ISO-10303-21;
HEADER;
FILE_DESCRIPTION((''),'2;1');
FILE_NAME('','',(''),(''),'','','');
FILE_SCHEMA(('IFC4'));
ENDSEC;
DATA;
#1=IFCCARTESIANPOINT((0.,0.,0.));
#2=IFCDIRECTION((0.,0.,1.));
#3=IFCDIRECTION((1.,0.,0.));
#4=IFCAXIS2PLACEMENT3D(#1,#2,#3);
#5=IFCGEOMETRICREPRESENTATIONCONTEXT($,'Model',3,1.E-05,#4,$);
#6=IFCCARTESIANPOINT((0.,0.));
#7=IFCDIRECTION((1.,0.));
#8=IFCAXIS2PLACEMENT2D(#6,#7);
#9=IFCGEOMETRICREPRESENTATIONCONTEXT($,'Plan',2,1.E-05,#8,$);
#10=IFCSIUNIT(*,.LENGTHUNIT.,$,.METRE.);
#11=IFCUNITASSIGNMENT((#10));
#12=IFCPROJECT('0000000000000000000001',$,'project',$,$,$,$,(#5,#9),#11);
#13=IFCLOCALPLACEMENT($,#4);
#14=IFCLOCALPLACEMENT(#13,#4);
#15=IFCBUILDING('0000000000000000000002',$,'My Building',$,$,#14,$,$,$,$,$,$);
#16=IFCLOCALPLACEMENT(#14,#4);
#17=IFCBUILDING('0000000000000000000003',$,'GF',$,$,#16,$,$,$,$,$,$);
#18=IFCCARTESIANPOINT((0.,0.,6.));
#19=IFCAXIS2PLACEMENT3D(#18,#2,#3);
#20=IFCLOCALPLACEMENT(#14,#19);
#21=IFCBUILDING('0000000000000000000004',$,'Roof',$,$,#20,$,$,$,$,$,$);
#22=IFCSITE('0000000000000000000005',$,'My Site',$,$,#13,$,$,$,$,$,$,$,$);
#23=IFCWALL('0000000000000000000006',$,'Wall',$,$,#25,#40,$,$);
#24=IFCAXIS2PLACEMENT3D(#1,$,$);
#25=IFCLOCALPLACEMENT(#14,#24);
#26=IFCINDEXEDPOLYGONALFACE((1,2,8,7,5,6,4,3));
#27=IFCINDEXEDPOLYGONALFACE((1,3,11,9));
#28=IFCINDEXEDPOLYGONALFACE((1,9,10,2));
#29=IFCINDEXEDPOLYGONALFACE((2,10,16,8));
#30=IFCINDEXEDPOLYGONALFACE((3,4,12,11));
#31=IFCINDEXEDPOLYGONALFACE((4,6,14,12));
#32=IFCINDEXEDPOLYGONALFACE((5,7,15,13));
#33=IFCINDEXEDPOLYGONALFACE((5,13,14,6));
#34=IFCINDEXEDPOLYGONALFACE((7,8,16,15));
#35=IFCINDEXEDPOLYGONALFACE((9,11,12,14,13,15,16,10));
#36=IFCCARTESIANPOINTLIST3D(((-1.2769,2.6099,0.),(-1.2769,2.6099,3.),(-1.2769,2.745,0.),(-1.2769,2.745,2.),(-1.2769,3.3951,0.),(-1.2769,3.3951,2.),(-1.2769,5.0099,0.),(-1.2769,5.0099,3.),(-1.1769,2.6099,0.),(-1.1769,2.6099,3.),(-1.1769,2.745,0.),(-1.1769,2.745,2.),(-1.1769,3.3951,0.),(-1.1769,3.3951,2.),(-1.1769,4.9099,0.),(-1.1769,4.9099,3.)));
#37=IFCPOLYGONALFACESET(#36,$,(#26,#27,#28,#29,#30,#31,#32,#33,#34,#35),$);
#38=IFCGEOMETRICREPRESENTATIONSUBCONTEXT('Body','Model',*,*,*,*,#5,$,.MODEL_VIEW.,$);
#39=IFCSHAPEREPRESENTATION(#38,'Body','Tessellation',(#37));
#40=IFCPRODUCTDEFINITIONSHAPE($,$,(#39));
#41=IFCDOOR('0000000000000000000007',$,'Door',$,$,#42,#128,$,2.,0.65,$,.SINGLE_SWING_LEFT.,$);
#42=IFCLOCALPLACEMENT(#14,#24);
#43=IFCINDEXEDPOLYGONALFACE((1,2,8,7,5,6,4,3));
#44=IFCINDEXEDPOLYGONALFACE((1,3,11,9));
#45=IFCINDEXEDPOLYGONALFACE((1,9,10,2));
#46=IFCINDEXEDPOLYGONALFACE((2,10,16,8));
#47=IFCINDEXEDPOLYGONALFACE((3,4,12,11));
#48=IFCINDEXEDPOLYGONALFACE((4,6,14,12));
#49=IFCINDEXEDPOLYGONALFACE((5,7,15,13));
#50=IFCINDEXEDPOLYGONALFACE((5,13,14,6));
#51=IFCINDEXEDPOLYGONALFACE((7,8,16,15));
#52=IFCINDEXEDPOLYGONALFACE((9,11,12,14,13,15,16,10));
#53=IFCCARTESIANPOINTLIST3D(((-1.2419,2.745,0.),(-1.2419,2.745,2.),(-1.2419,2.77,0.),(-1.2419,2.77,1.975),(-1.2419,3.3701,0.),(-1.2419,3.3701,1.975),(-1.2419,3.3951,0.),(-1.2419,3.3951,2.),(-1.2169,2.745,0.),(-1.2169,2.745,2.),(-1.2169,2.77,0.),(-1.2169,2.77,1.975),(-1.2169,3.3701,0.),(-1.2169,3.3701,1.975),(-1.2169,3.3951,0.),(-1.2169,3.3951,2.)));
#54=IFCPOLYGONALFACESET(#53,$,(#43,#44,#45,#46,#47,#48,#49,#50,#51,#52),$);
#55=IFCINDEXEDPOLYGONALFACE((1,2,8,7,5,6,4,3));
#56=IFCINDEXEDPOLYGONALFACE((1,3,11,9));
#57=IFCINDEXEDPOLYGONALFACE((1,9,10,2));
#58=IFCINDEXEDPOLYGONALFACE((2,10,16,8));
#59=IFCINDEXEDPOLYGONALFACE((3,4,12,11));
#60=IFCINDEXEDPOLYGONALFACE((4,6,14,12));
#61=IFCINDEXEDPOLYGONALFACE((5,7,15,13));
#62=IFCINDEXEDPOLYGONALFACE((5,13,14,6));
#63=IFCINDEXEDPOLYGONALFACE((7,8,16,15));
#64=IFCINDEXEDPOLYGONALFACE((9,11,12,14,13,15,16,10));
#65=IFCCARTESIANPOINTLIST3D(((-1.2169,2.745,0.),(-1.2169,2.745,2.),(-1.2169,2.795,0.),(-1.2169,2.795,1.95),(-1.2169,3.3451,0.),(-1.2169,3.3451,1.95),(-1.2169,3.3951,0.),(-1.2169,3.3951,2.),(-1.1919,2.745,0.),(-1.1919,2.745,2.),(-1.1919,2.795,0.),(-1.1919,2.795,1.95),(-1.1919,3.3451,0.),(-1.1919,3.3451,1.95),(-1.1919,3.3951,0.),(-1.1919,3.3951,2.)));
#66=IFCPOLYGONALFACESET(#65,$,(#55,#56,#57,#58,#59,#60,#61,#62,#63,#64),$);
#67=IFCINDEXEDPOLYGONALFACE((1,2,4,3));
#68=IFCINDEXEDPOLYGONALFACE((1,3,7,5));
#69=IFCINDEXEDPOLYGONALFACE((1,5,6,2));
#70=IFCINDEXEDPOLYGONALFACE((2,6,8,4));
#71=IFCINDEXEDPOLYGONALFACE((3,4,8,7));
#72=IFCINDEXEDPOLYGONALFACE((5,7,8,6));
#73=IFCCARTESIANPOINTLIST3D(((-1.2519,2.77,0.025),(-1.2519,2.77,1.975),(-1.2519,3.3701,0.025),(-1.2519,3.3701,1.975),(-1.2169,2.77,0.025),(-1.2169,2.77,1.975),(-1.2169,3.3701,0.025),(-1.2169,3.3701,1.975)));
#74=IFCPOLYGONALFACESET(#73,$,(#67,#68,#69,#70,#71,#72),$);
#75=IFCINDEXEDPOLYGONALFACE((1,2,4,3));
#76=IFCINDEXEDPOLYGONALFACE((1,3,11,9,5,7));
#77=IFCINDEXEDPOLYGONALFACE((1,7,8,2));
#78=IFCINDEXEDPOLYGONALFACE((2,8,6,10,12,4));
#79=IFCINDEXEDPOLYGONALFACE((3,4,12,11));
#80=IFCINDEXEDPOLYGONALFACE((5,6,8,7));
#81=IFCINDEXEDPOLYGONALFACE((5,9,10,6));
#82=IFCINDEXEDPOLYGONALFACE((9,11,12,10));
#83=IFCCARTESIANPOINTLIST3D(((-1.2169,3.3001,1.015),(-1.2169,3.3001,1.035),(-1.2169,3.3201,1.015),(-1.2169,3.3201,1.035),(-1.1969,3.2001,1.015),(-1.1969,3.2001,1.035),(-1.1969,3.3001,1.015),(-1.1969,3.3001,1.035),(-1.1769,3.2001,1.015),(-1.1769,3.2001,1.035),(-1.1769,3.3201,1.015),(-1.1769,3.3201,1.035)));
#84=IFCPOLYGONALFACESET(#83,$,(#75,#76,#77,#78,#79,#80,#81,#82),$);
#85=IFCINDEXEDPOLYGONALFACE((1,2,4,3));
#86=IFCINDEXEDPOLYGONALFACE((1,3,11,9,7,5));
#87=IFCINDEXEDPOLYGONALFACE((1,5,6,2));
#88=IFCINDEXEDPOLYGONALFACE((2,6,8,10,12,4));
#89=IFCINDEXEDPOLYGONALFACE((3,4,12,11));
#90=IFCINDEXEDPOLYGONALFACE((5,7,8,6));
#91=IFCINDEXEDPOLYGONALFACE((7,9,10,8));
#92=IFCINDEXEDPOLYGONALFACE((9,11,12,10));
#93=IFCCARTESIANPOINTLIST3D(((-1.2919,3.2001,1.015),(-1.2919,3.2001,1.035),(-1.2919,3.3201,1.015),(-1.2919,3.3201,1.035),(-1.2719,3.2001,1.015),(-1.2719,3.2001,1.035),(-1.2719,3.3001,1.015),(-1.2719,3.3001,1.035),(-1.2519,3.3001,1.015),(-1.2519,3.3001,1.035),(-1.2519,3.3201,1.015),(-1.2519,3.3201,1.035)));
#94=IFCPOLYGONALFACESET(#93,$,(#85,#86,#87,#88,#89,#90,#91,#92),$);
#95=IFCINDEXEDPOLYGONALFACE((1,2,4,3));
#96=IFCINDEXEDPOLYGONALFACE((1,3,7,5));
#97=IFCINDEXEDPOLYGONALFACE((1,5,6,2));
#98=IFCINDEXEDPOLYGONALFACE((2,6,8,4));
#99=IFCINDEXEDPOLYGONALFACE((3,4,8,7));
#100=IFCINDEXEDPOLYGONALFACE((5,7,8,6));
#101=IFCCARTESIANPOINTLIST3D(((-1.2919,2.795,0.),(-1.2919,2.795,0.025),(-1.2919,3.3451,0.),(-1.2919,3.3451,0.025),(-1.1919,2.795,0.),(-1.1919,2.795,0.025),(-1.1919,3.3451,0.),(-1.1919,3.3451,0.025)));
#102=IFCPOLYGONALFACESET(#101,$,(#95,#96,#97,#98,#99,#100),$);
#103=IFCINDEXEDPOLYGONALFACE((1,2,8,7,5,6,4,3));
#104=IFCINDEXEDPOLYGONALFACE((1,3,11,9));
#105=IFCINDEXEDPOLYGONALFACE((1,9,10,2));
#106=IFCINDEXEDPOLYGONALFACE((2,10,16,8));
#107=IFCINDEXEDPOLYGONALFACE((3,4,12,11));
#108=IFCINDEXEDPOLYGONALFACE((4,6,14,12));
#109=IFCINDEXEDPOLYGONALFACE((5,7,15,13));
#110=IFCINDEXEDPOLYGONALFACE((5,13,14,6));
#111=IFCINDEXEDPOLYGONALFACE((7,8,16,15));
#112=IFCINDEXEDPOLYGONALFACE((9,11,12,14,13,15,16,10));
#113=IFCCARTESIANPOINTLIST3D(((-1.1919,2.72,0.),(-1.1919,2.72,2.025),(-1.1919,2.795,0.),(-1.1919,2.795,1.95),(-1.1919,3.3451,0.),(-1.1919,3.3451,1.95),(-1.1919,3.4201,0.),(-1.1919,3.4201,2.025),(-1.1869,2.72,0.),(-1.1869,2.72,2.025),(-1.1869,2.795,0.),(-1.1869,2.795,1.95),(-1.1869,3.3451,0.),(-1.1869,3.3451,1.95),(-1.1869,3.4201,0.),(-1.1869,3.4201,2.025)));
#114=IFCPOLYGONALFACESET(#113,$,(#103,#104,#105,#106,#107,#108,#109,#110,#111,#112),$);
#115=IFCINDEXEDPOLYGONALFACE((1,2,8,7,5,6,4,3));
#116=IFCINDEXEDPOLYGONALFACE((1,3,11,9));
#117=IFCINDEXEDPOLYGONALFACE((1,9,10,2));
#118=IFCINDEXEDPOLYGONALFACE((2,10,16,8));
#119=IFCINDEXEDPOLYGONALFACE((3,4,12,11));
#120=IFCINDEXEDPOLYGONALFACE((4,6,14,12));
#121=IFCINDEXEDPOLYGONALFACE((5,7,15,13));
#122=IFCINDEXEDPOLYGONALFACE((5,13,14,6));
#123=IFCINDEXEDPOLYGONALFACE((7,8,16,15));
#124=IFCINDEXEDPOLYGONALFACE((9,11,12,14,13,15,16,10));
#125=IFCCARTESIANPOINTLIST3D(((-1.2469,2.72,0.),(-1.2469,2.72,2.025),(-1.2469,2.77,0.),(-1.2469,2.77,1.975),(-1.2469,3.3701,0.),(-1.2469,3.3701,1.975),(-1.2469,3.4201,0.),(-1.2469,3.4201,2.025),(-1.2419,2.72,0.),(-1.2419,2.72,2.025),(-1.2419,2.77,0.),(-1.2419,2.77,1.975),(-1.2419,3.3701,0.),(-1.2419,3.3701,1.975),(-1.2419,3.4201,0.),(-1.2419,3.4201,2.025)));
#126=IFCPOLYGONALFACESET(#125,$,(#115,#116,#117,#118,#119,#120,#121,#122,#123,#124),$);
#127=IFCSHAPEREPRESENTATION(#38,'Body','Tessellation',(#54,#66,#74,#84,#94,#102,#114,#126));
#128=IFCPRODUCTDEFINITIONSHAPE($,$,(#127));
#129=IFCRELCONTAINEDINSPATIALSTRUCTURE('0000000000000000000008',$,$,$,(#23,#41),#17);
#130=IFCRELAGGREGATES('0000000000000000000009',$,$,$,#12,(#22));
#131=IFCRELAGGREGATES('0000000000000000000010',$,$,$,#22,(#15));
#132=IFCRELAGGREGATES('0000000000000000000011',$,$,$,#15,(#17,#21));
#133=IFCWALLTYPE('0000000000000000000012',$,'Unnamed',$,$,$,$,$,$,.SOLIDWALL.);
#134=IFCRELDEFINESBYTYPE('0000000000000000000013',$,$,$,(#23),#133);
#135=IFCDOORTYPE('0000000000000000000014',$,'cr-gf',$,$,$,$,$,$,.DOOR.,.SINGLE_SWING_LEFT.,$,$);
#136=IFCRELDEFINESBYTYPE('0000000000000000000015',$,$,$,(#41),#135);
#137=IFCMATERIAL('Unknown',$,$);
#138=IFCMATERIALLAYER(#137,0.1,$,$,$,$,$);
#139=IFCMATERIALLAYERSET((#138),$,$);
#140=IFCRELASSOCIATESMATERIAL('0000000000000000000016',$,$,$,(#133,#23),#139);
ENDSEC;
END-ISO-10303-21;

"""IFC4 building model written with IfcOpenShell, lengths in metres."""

from ifc_helpers import new_model, entity, si_unit, frame, origin_with_axes, origin_2d_with_axis, place, context, subcontext, project, spatial, line, indexed_curve, outline, extrude, shape, source, transform, mapped, material, layer, layer_set, layer_usage, type_object, type_shapes, element, fill, save


model = new_model("IFC4")

# Units and contexts
model_context = context("Model", 3, precision=1e-05, world=origin_with_axes())
plan_context = context("Plan", 2, precision=1e-05, world=origin_2d_with_axis())
body_context_1 = subcontext(model_context, "Body", "Model", "MODEL_VIEW")
body_context_2 = subcontext(plan_context, "Body", "Plan", "PLAN_VIEW")
ifc_project = project(units=[si_unit("LENGTHUNIT", "METRE")], contexts=[model_context, plan_context])

# Site, buildings
site_placement = place(None, origin_with_axes())
site = spatial("IfcSite", under=ifc_project, at=site_placement, Name="My Site")
building_1_placement = place(site_placement, origin_with_axes())
building_1 = spatial("IfcBuilding", under=site, at=building_1_placement, Name="My Building")
building_2_placement = place(building_1_placement, origin_with_axes())
building_2 = spatial("IfcBuilding", under=building_1, at=building_2_placement, Name="GF")

# Shared definitions
ifc_material = material(Name="Unknown")

# Shared definitions
building_3_placement = place(building_1_placement, frame((0.0, 0.0, 6.0), z_axis=(0.0, 0.0, 1.0), x_axis=(1.0, 0.0, 0.0)))
building_3 = spatial("IfcBuilding", under=building_1, at=building_3_placement, Name="Roof")

# Shared definitions
ifc_layer_1 = layer(ifc_material, 0.1)
ifc_layer_set_1 = layer_set([ifc_layer_1])
wall_type = type_object("IfcWallType", Name="Unnamed", PredefinedType="SOLIDWALL", material=ifc_layer_set_1)

# Wall, opening, door
ifc_layer_usage_1 = layer_usage(ifc_layer_set_1, "AXIS2", "POSITIVE", 0.0)
wall_1_placement = place(building_2_placement, frame((-1.1769, 2.6099, 0.0), z_axis=(0.0, 0.0, 1.0), x_axis=(0.0, 1.0, 0.0)))
wall_1 = element("IfcWall", 1, at=wall_1_placement, inside=building_2, type_object=wall_type, material=ifc_layer_usage_1, Name="Wall", context=body_context_1, shape_type="SweptSolid", body=[
    extrude(outline(indexed_curve([(0.0, 0.0), (0.0, 0.1), (2.4, 0.1), (2.3, 0.0)], segments=[line(1, 2, 3, 4, 1)])), origin_with_axes(), (0.0, 0.0, 1.0), 3.0),
])
shared_shape_1 = source(origin_with_axes(), body_context_1, "Body", "SweptSolid", [
    extrude(outline(indexed_curve([(0.0, 0.0), (0.65, 0.0), (0.65, 2.0), (0.0, 2.0)], segments=[line(1, 2, 3, 4, 1)])), frame((0.0, -0.6, 0.0), z_axis=(0.0, -1.0, 0.0), x_axis=(1.0, 0.0, 0.0)), (0.0, 0.0, -1.0), 1.2),
])
opening_1_placement = place(wall_1_placement, frame((0.1352, 0.015, 0.0), z_axis=(0.0, 0.0, 1.0), x_axis=(1.0, 0.0, 0.0)))
opening_1 = element("IfcOpeningElement", 2, at=opening_1_placement, cuts=wall_1, PredefinedType="OPENING", context=body_context_1, shape_type="MappedRepresentation", body=[
    mapped(shared_shape_1, transform((0.0, 0.0, 0.0), x_axis=(1.0, 0.0, 0.0), y_axis=(0.0, 1.0, 0.0), z_axis=(0.0, 0.0, 1.0), scale=1.0)),
])
door_type_1 = type_object("IfcDoorType", Name="cr-gf", OperationType="SINGLE_SWING_LEFT", PredefinedType="DOOR")
shared_shape_2 = source(origin_with_axes(), body_context_1, "Body", "SweptSolid", [
    extrude(outline(indexed_curve([(0.0, 0.0), (0.0, 2.0), (0.65, 2.0), (0.65, 0.0), (0.625, 0.0), (0.625, 1.975), (0.025, 1.975), (0.025, 0.0)], segments=[line(1, 2, 3, 4, 5, 6, 7, 8, 1)])), frame((0.0, 0.025, 0.0), z_axis=(0.0, -1.0, 0.0), x_axis=(1.0, 0.0, 0.0)), (0.0, 0.0, -1.0), 0.025),
    extrude(outline(indexed_curve([(0.0, 0.0), (0.0, 2.0), (0.65, 2.0), (0.65, 0.0), (0.6, 0.0), (0.6, 1.95), (0.05, 1.95), (0.05, 0.0)], segments=[line(1, 2, 3, 4, 5, 6, 7, 8, 1)])), frame((0.0, 0.0, 0.0), z_axis=(0.0, -1.0, 0.0), x_axis=(1.0, 0.0, 0.0)), (0.0, 0.0, -1.0), 0.025),
    extrude(outline(indexed_curve([(0.0, 0.0), (0.6, 0.0), (0.6, 0.035), (0.0, 0.035)], segments=[line(1, 2, 3, 4, 1)])), frame((0.025, 0.025, 0.025), z_axis=(0.0, 0.0, 1.0), x_axis=(1.0, 0.0, 0.0)), (0.0, 0.0, 1.0), 1.95),
    extrude(outline(indexed_curve([(0.0, 0.0), (0.0, -0.04), (-0.12, -0.04), (-0.12, -0.02), (-0.02, -0.02), (-0.02, 0.0)], segments=[line(1, 2, 3, 4, 5, 6, 1)])), frame((0.575, 0.025, 1.015), z_axis=(0.0, 0.0, 1.0), x_axis=(1.0, 0.0, 0.0)), (0.0, 0.0, 1.0), 0.02),
    extrude(outline(indexed_curve([(0.0, 0.0), (0.0, 0.04), (-0.12, 0.04), (-0.12, 0.02), (-0.02, 0.02), (-0.02, 0.0)], segments=[line(1, 2, 3, 4, 5, 6, 1)])), frame((0.575, 0.06, 1.015), z_axis=(0.0, 0.0, 1.0), x_axis=(1.0, 0.0, 0.0)), (0.0, 0.0, 1.0), 0.02),
    extrude(outline(indexed_curve([(0.0, 0.0), (0.55, 0.0), (0.55, 0.1), (0.0, 0.1)], segments=[line(1, 2, 3, 4, 1)])), frame((0.05, 0.0, 0.0), z_axis=(0.0, 0.0, 1.0), x_axis=(1.0, 0.0, 0.0)), (0.0, 0.0, 1.0), 0.025),
    extrude(outline(indexed_curve([(0.0, 0.0), (0.0, 2.025), (0.7, 2.025), (0.7, 0.0), (0.625, 0.0), (0.625, 1.95), (0.075, 1.95), (0.075, 0.0)], segments=[line(1, 2, 3, 4, 5, 6, 7, 8, 1)])), frame((-0.025, -0.005, 0.0), z_axis=(0.0, -1.0, 0.0), x_axis=(1.0, 0.0, 0.0)), (0.0, 0.0, -1.0), 0.005),
    extrude(outline(indexed_curve([(0.0, 0.0), (0.0, 2.025), (0.7, 2.025), (0.7, 0.0), (0.65, 0.0), (0.65, 1.975), (0.05, 1.975), (0.05, 0.0)], segments=[line(1, 2, 3, 4, 5, 6, 7, 8, 1)])), frame((-0.025, 0.05, 0.0), z_axis=(0.0, -1.0, 0.0), x_axis=(1.0, 0.0, 0.0)), (0.0, 0.0, -1.0), 0.005),
])
shared_shape_3 = source(origin_with_axes(), body_context_2, "Body", "Curve2D", [
    entity("IfcIndexedPolyCurve", entity("IfcCartesianPointList2D", [[0.0, 0.0], [0.0, 0.05], [0.025, 0.05], [0.025, 0.025], [0.05, 0.025], [0.05, 0.0]]), [entity("IfcLineIndex", [1, 2, 3, 4, 5, 6, 1])]),
    entity("IfcIndexedPolyCurve", entity("IfcCartesianPointList2D", [[0.65, 0.0], [0.65, 0.05], [0.625, 0.05], [0.625, 0.025], [0.6, 0.025], [0.6, 0.0]]), [entity("IfcLineIndex", [1, 2, 3, 4, 5, 6, 1])]),
    entity("IfcTrimmedCurve", entity("IfcEllipse", entity("IfcAxis2Placement2D", entity("IfcCartesianPoint", [0.06, 0.05]), entity("IfcDirection", [1.0, 0.0])), 0.565, 0.6), [entity("IfcCartesianPoint", [0.625, 0.05])], [entity("IfcCartesianPoint", [0.06, 0.65])], True, "CARTESIAN"),
    entity("IfcIndexedPolyCurve", entity("IfcCartesianPointList2D", [[0.025, 0.05], [0.06, 0.05], [0.06, 0.65], [0.025, 0.65]]), [entity("IfcLineIndex", [1, 2, 3, 4, 1])]),
])
type_shapes(door_type_1, [shared_shape_2, shared_shape_3])
door_1_placement = place(opening_1_placement, frame((0.0, 0.0, 0.0), z_axis=(0.0, 0.0, 1.0), x_axis=(1.0, 0.0, 0.0)))
door_1 = element("IfcDoor", 3, at=door_1_placement, inside=building_2, type_object=door_type_1, Name="Door", OperationType="SINGLE_SWING_LEFT", OverallHeight=2.0, OverallWidth=0.65, shapes=[
    shape(body_context_1, "Body", "MappedRepresentation", [mapped(shared_shape_2, transform((0.0, 0.0, 0.0), x_axis=(1.0, 0.0, 0.0), y_axis=(0.0, 1.0, 0.0), z_axis=(0.0, 0.0, 1.0), scale=1.0))]),
    shape(body_context_2, "Body", "MappedRepresentation", [mapped(shared_shape_3, transform((0.0, 0.0, 0.0), x_axis=(1.0, 0.0, 0.0), y_axis=(0.0, 1.0, 0.0), z_axis=(0.0, 0.0, 1.0), scale=1.0))]),
])
fill(opening_1, door_1)

save(model, "model.ifc")
